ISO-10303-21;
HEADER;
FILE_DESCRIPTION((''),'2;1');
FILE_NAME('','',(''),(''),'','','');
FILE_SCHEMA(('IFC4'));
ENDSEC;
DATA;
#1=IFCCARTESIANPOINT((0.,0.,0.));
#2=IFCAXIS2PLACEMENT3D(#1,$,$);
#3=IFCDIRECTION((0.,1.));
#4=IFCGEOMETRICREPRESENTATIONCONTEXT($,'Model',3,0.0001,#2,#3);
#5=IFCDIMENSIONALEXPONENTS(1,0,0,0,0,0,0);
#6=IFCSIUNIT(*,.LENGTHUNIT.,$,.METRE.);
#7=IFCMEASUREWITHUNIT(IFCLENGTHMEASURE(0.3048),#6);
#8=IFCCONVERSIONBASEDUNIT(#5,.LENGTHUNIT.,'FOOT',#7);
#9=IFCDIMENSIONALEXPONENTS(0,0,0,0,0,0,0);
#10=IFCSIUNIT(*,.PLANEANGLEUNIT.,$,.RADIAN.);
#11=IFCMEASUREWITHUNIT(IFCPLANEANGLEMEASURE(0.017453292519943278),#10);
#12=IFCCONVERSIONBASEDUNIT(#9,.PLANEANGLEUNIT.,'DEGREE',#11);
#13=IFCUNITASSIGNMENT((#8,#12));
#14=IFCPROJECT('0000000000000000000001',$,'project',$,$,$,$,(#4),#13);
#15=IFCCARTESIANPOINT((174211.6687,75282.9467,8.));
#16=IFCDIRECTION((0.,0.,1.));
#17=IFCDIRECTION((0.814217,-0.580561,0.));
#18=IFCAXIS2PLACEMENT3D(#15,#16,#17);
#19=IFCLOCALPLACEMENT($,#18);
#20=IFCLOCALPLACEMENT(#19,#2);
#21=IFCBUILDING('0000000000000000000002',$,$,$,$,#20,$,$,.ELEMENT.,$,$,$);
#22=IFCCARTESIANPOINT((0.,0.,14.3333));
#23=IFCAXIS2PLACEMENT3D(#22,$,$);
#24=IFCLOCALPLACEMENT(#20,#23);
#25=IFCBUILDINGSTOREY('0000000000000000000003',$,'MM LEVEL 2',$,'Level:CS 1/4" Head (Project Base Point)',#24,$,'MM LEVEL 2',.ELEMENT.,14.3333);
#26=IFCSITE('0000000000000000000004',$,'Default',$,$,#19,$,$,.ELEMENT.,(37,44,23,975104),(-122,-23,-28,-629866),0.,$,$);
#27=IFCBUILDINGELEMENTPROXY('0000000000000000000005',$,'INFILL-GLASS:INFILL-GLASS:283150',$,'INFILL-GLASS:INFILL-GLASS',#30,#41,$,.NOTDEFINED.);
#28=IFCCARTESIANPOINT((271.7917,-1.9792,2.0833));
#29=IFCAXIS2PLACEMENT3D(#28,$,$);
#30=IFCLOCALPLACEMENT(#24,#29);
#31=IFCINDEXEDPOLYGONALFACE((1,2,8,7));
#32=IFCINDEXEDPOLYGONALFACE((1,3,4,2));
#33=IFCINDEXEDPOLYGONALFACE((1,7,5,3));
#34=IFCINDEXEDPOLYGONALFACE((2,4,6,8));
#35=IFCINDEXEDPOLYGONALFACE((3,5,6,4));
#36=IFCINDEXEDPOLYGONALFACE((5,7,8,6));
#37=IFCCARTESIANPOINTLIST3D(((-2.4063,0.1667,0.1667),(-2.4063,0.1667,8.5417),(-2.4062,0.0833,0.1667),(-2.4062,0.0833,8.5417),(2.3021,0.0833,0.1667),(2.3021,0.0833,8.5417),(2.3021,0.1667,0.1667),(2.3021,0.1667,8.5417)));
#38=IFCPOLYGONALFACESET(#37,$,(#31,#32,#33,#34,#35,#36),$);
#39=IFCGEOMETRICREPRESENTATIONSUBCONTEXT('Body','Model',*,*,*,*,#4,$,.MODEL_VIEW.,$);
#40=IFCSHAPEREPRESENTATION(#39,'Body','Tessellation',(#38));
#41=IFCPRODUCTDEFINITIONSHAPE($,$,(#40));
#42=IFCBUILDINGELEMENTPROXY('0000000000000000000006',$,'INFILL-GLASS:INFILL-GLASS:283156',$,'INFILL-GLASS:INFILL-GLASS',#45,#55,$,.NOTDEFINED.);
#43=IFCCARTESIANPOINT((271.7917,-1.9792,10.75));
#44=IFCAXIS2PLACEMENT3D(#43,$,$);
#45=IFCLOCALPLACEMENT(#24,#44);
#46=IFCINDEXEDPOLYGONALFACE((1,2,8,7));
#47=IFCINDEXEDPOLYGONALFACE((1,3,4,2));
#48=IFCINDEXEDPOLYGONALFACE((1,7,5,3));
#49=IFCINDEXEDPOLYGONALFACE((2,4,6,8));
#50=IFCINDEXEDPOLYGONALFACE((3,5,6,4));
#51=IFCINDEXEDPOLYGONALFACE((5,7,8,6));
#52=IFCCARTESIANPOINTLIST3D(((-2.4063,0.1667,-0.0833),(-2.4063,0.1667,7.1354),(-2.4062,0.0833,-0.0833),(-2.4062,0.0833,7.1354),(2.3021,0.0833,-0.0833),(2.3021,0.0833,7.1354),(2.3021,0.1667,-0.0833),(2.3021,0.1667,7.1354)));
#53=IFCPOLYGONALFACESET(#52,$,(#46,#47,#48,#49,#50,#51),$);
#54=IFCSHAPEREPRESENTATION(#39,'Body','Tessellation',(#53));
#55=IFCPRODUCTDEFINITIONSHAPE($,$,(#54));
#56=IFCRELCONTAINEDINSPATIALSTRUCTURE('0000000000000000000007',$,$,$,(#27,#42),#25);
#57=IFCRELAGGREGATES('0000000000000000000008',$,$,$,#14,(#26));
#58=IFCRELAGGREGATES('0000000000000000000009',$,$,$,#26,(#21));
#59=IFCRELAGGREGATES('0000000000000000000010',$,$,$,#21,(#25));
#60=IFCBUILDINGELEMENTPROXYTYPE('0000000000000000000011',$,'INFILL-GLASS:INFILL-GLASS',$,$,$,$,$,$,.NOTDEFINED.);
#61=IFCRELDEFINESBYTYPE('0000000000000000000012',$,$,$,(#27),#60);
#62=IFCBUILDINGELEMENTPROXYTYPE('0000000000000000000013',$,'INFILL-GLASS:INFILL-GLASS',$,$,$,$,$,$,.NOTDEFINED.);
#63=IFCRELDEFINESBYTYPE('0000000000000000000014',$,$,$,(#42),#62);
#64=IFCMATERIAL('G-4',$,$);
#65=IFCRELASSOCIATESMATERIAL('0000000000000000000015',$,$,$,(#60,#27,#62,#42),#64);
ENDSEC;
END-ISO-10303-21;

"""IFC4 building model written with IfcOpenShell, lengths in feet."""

from ifc_helpers import new_model, entity, si_unit, converted_unit, direction, frame, origin, place, context, subcontext, project, spatial, indexed_curve, outline, extrude, source, transform, mapped, material, type_object, type_shapes, element, save


model = new_model("IFC4")

# Units and contexts
model_context = context("Model", 3, precision=0.0001, world=origin(), true_north=direction((0.0, 1.0)))
body_context = subcontext(model_context, "Body", "Model", "MODEL_VIEW")
ifc_project = project(units=[converted_unit("LENGTHUNIT", "FOOT", entity("IfcLengthMeasure", 0.3048), si_unit("LENGTHUNIT", "METRE"), dimensions=[1, 0, 0, 0, 0, 0, 0]), converted_unit("PLANEANGLEUNIT", "DEGREE", entity("IfcPlaneAngleMeasure", 0.017453292519943278), si_unit("PLANEANGLEUNIT", "RADIAN"), dimensions=[0, 0, 0, 0, 0, 0, 0])], contexts=[model_context])

# Site, building, storey
site_placement = place(None, frame((174211.6687, 75282.9467, 8.0), z_axis=(0.0, 0.0, 1.0), x_axis=(0.814217, -0.580561, 0.0)))
site = spatial("IfcSite", under=ifc_project, at=site_placement, Name="Default", CompositionType="ELEMENT", RefLatitude=(37, 44, 23, 975104), RefLongitude=(-122, -23, -28, -629866), RefElevation=0.0)
building_placement = place(site_placement, origin())
building = spatial("IfcBuilding", under=site, at=building_placement, CompositionType="ELEMENT")
storey_placement = place(building_placement, frame((0.0, 0.0, 14.3333)))
storey = spatial("IfcBuildingStorey", under=building, at=storey_placement, Name="MM LEVEL 2", ObjectType="Level:CS 1/4\" Head (Project Base Point)", LongName="MM LEVEL 2", CompositionType="ELEMENT", Elevation=14.3333)

# Building element proxies
ifc_material_1 = material(Name="G-4")
building_element_proxy_type_1 = type_object("IfcBuildingElementProxyType", Name="INFILL-GLASS:INFILL-GLASS", PredefinedType="NOTDEFINED", material=ifc_material_1)
shared_shape_1 = source(origin(), body_context, "Body", "SweptSolid", [
    extrude(outline(indexed_curve([(-0.0417, -2.3542), (0.0417, -2.3542), (0.0417, 2.3542), (-0.0417, 2.3542), (-0.0417, -2.3542)], self_intersect=False)), frame((-0.0521, 0.125, 0.1667), z_axis=(0.0, 0.0, 1.0), x_axis=(0.0, 1.0, 0.0)), (0.0, 0.0, 1.0), 8.375),
])
type_shapes(building_element_proxy_type_1, [shared_shape_1])
proxy_1_placement = place(storey_placement, frame((271.7917, -1.9792, 2.0833)))
element("IfcBuildingElementProxy", 1, at=proxy_1_placement, inside=storey, type_object=building_element_proxy_type_1, material=ifc_material_1, Name="INFILL-GLASS:INFILL-GLASS:283150", ObjectType="INFILL-GLASS:INFILL-GLASS", PredefinedType="NOTDEFINED", context=body_context, shape_type="MappedRepresentation", body=[
    mapped(shared_shape_1, transform((0.0, 0.0, 0.0), scale=1.0)),
])
building_element_proxy_type_2 = type_object("IfcBuildingElementProxyType", Name="INFILL-GLASS:INFILL-GLASS", PredefinedType="NOTDEFINED", material=ifc_material_1)
shared_shape_2 = source(origin(), body_context, "Body", "SweptSolid", [
    extrude(outline(indexed_curve([(-0.0417, -2.3542), (0.0417, -2.3542), (0.0417, 2.3542), (-0.0417, 2.3542), (-0.0417, -2.3542)], self_intersect=False)), frame((-0.0521, 0.125, -0.0833), z_axis=(0.0, 0.0, 1.0), x_axis=(0.0, 1.0, 0.0)), (0.0, 0.0, 1.0), 7.2187),
])
type_shapes(building_element_proxy_type_2, [shared_shape_2])
proxy_2_placement = place(storey_placement, frame((271.7917, -1.9792, 10.75)))
element("IfcBuildingElementProxy", 2, at=proxy_2_placement, inside=storey, type_object=building_element_proxy_type_2, material=ifc_material_1, Name="INFILL-GLASS:INFILL-GLASS:283156", ObjectType="INFILL-GLASS:INFILL-GLASS", PredefinedType="NOTDEFINED", context=body_context, shape_type="MappedRepresentation", body=[
    mapped(shared_shape_2, transform((0.0, 0.0, 0.0), scale=1.0)),
])

save(model, "model.ifc")
